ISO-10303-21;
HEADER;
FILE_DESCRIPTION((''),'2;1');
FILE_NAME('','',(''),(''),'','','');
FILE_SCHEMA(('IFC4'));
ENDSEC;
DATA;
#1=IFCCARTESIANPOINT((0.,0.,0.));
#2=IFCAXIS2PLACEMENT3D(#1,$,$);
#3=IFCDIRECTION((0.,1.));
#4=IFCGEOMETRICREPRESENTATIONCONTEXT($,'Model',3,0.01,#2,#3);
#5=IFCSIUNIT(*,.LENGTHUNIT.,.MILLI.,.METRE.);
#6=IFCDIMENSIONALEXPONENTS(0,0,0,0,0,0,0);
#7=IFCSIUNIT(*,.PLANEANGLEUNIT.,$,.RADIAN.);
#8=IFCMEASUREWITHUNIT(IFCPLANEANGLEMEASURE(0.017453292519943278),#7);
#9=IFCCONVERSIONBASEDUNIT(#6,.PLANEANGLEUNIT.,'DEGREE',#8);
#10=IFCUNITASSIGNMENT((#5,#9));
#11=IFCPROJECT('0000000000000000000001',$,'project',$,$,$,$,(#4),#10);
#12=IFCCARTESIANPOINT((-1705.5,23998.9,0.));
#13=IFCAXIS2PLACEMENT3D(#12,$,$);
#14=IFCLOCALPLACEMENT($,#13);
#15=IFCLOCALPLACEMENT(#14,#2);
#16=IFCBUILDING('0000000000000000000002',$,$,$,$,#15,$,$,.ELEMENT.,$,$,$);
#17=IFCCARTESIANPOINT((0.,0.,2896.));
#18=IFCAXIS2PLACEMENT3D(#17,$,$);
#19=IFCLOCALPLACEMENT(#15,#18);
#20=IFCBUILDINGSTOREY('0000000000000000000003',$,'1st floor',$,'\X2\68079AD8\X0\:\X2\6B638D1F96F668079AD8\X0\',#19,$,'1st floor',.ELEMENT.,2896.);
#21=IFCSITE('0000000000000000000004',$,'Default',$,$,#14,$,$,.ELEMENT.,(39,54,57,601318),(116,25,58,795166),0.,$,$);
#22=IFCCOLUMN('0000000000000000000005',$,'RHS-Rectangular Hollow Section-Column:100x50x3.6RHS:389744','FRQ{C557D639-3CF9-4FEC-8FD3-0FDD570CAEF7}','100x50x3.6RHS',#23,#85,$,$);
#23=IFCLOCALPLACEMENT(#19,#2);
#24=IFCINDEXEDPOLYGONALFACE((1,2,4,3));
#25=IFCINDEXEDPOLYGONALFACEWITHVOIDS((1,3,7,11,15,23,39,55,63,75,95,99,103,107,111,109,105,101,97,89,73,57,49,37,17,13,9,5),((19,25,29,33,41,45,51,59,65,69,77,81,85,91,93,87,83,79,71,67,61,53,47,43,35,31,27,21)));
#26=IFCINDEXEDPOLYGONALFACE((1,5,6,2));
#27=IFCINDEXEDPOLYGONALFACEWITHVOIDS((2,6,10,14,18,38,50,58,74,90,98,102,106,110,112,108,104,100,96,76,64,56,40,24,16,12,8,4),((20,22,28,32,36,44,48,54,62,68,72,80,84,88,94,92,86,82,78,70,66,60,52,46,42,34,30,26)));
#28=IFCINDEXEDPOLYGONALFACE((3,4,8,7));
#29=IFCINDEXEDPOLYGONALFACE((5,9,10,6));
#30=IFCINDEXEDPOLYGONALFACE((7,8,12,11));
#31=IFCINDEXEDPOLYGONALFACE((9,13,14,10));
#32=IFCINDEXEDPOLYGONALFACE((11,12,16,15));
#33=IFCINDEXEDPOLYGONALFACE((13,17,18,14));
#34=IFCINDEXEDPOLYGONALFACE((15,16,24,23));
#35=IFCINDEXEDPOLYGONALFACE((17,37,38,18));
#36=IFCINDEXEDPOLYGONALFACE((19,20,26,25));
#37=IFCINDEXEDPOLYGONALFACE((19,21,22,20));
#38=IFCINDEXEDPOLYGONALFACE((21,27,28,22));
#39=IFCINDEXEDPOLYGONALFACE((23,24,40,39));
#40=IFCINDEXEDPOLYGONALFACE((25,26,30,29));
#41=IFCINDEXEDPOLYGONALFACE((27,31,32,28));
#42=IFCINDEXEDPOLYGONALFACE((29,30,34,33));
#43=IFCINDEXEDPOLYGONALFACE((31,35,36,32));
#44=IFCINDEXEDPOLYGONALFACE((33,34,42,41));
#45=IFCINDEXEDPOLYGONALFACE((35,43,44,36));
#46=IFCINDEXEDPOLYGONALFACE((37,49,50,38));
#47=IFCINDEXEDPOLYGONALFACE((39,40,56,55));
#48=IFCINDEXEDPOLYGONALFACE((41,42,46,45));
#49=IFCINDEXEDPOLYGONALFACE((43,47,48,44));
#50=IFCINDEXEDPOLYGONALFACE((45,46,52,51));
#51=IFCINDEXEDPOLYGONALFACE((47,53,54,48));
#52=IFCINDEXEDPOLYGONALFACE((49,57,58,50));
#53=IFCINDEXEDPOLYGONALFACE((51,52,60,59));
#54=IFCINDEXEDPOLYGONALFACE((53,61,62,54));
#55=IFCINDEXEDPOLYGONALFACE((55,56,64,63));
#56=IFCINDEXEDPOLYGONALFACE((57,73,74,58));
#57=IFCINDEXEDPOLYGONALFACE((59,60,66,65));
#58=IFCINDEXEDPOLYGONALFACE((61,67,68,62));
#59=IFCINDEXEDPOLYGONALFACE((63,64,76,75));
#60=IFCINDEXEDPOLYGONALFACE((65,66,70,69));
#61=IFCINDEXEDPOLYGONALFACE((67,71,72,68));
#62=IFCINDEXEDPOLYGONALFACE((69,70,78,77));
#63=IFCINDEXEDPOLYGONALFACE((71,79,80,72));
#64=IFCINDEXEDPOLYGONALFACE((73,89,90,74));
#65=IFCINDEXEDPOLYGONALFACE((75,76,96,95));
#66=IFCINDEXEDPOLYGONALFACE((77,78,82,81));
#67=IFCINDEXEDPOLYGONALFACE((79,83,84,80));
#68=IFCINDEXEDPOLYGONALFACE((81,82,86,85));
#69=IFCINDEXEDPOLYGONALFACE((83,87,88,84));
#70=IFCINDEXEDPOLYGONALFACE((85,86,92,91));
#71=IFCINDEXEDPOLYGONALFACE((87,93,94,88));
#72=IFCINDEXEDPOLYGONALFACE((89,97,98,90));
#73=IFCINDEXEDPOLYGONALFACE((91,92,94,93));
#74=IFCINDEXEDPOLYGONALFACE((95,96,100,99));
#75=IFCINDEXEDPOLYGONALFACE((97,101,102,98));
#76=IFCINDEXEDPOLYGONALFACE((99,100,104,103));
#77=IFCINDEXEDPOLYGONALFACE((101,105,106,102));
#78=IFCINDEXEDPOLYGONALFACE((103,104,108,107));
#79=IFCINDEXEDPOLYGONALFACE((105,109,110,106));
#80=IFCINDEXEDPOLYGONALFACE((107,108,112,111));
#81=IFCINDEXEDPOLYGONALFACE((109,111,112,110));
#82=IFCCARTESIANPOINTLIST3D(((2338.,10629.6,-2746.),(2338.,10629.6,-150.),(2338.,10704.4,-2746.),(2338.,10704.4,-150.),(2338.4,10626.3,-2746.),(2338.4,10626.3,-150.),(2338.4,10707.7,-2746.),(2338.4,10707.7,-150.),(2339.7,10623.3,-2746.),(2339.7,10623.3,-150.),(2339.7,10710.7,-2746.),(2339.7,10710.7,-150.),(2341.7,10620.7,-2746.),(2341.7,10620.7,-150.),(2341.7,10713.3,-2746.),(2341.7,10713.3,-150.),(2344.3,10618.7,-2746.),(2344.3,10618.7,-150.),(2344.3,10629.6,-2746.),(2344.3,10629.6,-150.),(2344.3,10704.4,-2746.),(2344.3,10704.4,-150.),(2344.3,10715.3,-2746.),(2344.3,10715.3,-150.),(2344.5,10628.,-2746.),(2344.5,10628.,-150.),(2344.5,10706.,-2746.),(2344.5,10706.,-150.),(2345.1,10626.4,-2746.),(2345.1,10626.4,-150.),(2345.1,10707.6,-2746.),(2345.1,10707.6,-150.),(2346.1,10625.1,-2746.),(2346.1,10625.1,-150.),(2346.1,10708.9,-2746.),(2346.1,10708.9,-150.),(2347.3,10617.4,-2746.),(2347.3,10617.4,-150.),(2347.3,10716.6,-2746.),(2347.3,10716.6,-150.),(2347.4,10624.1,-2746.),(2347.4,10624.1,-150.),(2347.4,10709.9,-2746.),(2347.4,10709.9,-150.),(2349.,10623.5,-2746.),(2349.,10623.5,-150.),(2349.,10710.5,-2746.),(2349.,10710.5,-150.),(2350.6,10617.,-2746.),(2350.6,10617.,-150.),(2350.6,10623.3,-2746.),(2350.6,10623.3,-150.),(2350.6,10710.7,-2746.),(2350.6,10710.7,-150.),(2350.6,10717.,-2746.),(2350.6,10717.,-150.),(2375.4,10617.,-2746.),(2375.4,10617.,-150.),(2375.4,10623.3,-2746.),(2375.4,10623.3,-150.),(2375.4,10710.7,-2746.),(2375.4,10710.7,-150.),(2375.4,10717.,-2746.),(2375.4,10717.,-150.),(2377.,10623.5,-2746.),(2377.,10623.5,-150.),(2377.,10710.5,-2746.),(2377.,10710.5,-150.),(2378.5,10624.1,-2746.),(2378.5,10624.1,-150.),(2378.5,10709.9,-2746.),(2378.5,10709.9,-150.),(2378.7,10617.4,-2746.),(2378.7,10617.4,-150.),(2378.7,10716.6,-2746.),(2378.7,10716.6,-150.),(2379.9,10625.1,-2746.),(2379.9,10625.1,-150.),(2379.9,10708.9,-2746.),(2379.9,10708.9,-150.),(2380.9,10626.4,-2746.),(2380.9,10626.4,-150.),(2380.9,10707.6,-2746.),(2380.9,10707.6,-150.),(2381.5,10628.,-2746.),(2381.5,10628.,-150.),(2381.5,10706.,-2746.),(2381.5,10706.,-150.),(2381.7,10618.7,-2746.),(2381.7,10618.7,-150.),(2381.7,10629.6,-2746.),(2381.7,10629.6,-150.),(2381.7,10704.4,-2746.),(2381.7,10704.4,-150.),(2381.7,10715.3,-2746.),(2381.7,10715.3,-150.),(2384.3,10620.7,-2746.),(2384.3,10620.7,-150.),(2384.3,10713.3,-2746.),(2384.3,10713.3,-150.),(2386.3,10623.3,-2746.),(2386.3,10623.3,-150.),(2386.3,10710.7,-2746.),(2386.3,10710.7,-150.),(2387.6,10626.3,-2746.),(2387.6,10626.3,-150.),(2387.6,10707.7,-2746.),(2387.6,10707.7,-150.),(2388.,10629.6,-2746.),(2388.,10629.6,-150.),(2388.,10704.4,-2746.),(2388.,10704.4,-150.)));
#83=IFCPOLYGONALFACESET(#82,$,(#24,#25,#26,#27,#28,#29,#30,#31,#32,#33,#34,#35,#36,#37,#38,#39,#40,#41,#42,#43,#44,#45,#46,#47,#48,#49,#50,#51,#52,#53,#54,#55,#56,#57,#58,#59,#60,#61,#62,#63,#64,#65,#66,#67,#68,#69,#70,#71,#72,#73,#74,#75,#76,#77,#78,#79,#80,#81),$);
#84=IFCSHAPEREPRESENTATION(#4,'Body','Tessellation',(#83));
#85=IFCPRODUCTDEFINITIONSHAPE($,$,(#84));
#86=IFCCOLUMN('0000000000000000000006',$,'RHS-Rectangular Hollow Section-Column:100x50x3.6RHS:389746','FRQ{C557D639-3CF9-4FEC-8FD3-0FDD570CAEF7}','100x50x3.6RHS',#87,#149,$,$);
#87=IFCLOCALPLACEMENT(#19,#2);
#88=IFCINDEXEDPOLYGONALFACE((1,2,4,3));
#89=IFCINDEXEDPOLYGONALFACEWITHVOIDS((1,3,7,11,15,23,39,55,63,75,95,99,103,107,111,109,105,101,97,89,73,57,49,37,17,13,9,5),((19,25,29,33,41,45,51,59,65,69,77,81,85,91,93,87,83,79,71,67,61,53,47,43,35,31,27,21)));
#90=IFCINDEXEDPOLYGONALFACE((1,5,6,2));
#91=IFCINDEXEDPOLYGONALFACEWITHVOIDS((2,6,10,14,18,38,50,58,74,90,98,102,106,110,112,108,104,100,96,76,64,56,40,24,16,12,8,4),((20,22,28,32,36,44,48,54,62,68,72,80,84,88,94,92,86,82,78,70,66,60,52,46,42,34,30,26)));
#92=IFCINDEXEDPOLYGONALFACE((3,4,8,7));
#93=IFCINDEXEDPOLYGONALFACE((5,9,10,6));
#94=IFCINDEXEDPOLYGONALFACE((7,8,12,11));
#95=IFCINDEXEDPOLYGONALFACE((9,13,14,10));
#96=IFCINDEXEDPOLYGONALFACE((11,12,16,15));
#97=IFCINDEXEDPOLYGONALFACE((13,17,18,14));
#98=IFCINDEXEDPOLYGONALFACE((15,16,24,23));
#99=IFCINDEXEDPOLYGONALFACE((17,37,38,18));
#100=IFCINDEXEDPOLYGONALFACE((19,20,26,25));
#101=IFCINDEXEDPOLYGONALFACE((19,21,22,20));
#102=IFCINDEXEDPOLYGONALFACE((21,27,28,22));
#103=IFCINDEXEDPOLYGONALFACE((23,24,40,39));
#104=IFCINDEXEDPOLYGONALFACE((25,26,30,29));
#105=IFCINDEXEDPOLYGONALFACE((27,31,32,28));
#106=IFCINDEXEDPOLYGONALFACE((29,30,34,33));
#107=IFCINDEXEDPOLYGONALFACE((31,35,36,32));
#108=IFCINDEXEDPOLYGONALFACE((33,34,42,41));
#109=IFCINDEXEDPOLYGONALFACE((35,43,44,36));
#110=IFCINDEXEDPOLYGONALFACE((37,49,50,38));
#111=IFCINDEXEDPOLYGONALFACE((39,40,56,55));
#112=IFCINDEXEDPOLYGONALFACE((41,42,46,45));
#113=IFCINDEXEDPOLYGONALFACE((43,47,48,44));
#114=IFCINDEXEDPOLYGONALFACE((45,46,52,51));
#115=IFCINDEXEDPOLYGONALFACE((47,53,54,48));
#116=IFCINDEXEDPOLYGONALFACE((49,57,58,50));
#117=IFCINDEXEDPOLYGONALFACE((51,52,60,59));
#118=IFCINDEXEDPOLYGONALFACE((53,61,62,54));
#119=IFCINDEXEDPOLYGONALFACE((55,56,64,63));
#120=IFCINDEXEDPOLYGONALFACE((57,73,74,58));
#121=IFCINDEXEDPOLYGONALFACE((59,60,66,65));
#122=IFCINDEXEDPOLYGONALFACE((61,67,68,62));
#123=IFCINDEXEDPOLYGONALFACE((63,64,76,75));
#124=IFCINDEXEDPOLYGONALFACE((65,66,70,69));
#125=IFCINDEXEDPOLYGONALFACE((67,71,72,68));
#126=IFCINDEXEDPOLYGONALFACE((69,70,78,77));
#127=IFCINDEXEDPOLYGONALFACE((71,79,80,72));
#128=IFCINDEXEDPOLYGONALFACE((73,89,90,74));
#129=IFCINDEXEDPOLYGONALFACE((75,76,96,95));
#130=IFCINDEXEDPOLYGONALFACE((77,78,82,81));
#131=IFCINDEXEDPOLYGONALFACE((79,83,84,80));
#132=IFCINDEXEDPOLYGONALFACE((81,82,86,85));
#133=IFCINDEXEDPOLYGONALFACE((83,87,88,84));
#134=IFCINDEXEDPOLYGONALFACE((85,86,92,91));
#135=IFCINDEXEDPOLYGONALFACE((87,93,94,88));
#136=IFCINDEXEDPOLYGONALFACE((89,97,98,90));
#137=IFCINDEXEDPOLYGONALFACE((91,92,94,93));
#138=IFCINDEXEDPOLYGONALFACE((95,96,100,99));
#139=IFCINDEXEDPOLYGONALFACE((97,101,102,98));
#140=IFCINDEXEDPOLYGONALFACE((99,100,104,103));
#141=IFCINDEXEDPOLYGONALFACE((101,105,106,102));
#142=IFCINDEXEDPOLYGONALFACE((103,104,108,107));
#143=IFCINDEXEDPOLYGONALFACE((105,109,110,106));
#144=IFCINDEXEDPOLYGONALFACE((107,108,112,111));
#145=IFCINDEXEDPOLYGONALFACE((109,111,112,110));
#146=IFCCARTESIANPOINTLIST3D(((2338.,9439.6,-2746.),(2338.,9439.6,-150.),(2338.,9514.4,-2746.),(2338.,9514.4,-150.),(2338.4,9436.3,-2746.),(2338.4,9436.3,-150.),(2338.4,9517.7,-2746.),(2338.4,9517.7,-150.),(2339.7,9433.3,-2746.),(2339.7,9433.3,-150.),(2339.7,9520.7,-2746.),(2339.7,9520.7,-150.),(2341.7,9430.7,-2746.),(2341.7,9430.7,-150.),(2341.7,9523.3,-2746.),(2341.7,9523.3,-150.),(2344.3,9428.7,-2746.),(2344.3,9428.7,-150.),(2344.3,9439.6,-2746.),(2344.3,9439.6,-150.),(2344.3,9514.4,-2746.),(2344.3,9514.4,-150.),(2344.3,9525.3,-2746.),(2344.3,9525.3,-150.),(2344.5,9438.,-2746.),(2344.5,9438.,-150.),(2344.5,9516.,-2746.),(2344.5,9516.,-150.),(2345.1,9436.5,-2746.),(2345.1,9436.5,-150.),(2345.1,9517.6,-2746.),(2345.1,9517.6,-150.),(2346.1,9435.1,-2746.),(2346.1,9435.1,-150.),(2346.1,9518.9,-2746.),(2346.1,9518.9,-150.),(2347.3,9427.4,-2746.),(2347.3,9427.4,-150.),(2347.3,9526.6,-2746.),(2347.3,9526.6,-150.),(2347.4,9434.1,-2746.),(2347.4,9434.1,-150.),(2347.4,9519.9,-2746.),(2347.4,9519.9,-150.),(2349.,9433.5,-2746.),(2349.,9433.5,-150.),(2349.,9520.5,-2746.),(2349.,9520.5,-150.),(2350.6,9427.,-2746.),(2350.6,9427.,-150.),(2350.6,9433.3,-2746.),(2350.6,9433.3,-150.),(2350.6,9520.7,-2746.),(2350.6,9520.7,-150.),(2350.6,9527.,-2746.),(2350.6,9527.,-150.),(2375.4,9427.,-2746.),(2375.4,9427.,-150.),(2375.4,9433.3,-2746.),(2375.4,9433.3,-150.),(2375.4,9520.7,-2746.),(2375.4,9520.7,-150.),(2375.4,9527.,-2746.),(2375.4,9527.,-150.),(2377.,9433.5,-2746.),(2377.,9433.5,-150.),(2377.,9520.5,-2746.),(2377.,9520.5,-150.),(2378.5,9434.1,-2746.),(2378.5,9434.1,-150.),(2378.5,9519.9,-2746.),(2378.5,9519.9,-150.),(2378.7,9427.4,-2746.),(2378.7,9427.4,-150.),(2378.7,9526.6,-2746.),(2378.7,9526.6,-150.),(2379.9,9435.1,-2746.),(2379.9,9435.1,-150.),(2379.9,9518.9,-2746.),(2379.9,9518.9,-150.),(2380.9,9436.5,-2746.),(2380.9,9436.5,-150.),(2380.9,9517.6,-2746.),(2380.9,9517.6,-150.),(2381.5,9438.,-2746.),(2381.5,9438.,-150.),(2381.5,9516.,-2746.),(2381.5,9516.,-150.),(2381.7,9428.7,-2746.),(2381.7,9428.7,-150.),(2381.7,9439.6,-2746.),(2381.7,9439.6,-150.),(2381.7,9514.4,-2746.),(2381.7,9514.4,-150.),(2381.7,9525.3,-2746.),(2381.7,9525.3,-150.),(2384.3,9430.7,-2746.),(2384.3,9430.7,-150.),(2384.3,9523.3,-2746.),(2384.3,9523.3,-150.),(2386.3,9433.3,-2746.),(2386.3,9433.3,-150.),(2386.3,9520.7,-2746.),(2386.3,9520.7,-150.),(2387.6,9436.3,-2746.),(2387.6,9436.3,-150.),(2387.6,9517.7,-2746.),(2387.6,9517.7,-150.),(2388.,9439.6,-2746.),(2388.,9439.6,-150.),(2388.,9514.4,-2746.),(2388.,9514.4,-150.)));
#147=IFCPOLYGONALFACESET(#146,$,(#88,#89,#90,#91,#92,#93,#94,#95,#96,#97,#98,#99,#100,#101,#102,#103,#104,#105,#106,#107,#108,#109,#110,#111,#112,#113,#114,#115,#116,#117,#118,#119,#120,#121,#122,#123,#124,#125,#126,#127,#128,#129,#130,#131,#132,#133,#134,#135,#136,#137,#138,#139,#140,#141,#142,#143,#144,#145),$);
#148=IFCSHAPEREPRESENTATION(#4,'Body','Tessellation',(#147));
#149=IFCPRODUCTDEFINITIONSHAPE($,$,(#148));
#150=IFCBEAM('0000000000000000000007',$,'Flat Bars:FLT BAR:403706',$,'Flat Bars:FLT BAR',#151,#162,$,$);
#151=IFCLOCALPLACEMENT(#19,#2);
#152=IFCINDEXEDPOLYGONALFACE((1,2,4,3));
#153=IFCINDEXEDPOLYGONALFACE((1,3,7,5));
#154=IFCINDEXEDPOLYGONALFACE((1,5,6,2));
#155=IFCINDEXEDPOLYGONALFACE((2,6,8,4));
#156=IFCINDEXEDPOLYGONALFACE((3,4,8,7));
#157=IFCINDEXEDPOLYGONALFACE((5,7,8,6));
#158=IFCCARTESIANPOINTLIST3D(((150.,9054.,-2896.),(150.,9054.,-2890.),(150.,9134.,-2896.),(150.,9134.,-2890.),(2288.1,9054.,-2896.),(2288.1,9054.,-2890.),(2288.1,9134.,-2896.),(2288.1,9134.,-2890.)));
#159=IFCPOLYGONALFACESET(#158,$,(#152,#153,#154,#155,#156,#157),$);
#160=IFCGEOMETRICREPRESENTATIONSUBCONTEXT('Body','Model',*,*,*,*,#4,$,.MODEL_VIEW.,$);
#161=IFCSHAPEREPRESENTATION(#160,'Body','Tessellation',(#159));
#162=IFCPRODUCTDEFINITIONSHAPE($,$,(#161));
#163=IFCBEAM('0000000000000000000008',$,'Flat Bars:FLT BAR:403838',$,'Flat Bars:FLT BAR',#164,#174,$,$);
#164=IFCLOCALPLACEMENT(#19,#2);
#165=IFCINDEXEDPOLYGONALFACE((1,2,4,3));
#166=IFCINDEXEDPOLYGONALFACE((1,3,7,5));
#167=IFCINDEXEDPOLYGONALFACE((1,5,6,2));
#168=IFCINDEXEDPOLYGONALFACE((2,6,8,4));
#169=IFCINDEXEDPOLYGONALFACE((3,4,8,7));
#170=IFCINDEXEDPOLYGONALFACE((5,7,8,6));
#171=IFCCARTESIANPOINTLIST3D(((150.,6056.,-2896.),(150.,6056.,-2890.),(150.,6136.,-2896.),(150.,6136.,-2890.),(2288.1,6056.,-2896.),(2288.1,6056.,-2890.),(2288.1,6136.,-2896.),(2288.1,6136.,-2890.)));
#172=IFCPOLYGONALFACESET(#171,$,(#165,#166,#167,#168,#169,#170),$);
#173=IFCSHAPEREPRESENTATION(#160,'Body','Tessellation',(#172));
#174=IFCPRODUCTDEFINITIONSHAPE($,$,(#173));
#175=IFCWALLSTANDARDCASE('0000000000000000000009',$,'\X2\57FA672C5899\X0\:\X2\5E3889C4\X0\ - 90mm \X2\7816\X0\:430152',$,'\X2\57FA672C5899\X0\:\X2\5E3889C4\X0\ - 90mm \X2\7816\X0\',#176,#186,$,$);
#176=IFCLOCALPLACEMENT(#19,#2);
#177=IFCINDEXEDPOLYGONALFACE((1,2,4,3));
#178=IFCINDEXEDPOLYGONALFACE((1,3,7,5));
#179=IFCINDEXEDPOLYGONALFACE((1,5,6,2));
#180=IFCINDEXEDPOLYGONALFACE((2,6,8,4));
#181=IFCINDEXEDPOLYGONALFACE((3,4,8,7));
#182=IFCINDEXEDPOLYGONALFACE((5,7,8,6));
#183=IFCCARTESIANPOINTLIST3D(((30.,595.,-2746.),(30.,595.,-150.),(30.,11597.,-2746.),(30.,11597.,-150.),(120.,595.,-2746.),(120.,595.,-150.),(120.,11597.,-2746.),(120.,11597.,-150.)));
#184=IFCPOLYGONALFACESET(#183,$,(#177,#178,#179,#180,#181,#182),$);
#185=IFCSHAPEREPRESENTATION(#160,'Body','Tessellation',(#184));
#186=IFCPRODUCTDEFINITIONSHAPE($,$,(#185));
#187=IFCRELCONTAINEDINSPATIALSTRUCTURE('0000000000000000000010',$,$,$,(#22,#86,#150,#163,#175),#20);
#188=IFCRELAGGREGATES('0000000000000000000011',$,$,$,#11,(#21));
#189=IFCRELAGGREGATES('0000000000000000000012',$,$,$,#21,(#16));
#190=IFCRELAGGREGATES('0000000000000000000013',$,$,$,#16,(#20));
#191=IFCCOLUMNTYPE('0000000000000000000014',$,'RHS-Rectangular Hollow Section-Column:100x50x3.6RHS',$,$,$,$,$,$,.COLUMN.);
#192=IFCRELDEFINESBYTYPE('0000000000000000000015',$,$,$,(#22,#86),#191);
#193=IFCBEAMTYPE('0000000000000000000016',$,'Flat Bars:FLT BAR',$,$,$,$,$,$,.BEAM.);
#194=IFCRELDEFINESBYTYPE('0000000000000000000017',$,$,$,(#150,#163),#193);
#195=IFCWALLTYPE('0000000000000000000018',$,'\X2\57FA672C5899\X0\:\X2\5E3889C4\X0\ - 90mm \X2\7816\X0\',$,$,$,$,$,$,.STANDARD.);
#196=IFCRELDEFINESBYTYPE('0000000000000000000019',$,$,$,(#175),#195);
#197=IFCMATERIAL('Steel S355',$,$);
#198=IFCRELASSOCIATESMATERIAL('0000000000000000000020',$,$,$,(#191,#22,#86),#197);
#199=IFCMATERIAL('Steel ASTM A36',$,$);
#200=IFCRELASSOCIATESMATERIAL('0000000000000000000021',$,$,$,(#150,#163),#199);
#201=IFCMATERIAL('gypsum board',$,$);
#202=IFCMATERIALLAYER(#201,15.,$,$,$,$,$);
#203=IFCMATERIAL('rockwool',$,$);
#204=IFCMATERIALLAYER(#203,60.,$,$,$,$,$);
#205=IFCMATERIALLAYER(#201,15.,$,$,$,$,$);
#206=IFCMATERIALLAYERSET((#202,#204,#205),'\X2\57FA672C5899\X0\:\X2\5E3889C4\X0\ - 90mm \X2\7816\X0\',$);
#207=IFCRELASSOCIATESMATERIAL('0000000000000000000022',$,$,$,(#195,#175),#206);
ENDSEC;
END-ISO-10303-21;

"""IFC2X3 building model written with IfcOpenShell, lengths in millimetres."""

from ifc_helpers import new_model, entity, si_unit, converted_unit, direction, frame, frame_2d, origin, origin_2d, origin_2d_with_axis, place, context, subcontext, project, spatial, rectangle, hollow_rectangle, extrude, clip, halfspace, material, layer, layer_set, layer_usage, type_object, element, save


model = new_model("IFC2X3")

# Units and contexts
model_context = context("Model", 3, precision=0.01, world=origin(), true_north=direction((0.0, 1.0)))
body_context = subcontext(model_context, "Body", "Model", "MODEL_VIEW")
ifc_project = project(units=[si_unit("LENGTHUNIT", "METRE", prefix="MILLI"), converted_unit("PLANEANGLEUNIT", "DEGREE", entity("IfcPlaneAngleMeasure", 0.017453292519943278), si_unit("PLANEANGLEUNIT", "RADIAN"), dimensions=[0, 0, 0, 0, 0, 0, 0])], contexts=[model_context])

# Site, building, storey
site_placement = place(None, frame((-1705.5, 23998.9, 0.0)))
site = spatial("IfcSite", under=ifc_project, at=site_placement, Name="Default", CompositionType="ELEMENT", RefLatitude=(39, 54, 57, 601318), RefLongitude=(116, 25, 58, 795166), RefElevation=0.0)
building_placement = place(site_placement, origin())
building = spatial("IfcBuilding", under=site, at=building_placement, CompositionType="ELEMENT")
storey_placement = place(building_placement, frame((0.0, 0.0, 2896.0)))
storey = spatial("IfcBuildingStorey", under=building, at=storey_placement, Name="1st floor", ObjectType="标高:正负零标高", LongName="1st floor", CompositionType="ELEMENT", Elevation=2896.0)

# Columns
ifc_material_1 = material(Name="Steel S355")
column_type = type_object("IfcColumnType", Name="RHS-Rectangular Hollow Section-Column:100x50x3.6RHS", PredefinedType="COLUMN", material=ifc_material_1)
column_1_placement = place(storey_placement, frame((2363.0, 10667.0, -150.0), z_axis=(0.0, 0.0, 1.0), x_axis=(-1.0, 0.0, 0.0)))
element("IfcColumn", 1, at=column_1_placement, inside=storey, type_object=column_type, material=ifc_material_1, Name="RHS-Rectangular Hollow Section-Column:100x50x3.6RHS:389744", Description="FRQ{C557D639-3CF9-4FEC-8FD3-0FDD570CAEF7}", ObjectType="100x50x3.6RHS", context=model_context, shape_type="Clipping", body=[
    clip(extrude(hollow_rectangle(XDim=50.0, YDim=100.0, WallThickness=6.3, InnerFilletRadius=6.3, OuterFilletRadius=12.6, at=origin_2d()), origin(), (0.0, 0.0, -1.0), 2651.9), halfspace(frame((2363.0, 10667.0, -2596.0), z_axis=(0.0, 0.0, 1.0), x_axis=(-1.0, 0.0, 0.0)), True)),
])
column_2_placement = place(storey_placement, frame((2363.0, 9477.0, -150.0), z_axis=(0.0, 0.0, 1.0), x_axis=(-1.0, 0.0, 0.0)))
element("IfcColumn", 2, at=column_2_placement, inside=storey, type_object=column_type, material=ifc_material_1, Name="RHS-Rectangular Hollow Section-Column:100x50x3.6RHS:389746", Description="FRQ{C557D639-3CF9-4FEC-8FD3-0FDD570CAEF7}", ObjectType="100x50x3.6RHS", context=model_context, shape_type="Clipping", body=[
    clip(extrude(hollow_rectangle(XDim=50.0, YDim=100.0, WallThickness=6.3, InnerFilletRadius=6.3, OuterFilletRadius=12.6, at=origin_2d()), origin(), (0.0, 0.0, -1.0), 2651.9), halfspace(frame((2363.0, 9477.0, -2596.0), z_axis=(0.0, 0.0, 1.0), x_axis=(-1.0, 0.0, 0.0)), True)),
])

# Beams
ifc_material_2 = material(Name="Steel ASTM A36")
beam_type_1 = type_object("IfcBeamType", Name="Flat Bars:FLT BAR", PredefinedType="BEAM")
for number, where, name in (
    (3, (150.0, 9094.0, -2890.0), "Flat Bars:FLT BAR:403706"),
    (4, (150.0, 6096.0, -2890.0), "Flat Bars:FLT BAR:403838"),
):
    element("IfcBeam", number, at=place(storey_placement, frame(where)), inside=storey, type_object=beam_type_1, material=ifc_material_2, Name=name, ObjectType="Flat Bars:FLT BAR", context=body_context, shape_type="SweptSolid", body=[
        extrude(rectangle(XDim=6.0, YDim=80.0, at=origin_2d_with_axis()), frame((0.0, 0.0, -3.0), z_axis=(1.0, 0.0, 0.0), x_axis=(0.0, 0.0, -1.0)), (0.0, 0.0, 1.0), 2138.1),
    ])

# Wall
ifc_material_3 = material(Name="gypsum board")
ifc_layer_1 = layer(ifc_material_3, 15.0)
ifc_material_4 = material(Name="rockwool")
ifc_layer_2 = layer(ifc_material_4, 60.0)
ifc_layer_3 = layer(ifc_material_3, 15.0)
ifc_layer_set = layer_set([ifc_layer_1, ifc_layer_2, ifc_layer_3], Name="基本墙:常规 - 90mm 砖")
ifc_layer_usage = layer_usage(ifc_layer_set, "AXIS2", "NEGATIVE", 45.0)
wall_type = type_object("IfcWallType", Name="基本墙:常规 - 90mm 砖", PredefinedType="STANDARD", material=ifc_layer_set)
wall_placement = place(storey_placement, frame((75.0, 11597.0, -2746.0), z_axis=(0.0, 0.0, 1.0), x_axis=(0.0, -1.0, 0.0)))
element("IfcWallStandardCase", 5, at=wall_placement, inside=storey, type_object=wall_type, material=ifc_layer_usage, Name="基本墙:常规 - 90mm 砖:430152", ObjectType="基本墙:常规 - 90mm 砖", context=body_context, shape_type="SweptSolid", body=[
    extrude(rectangle(XDim=11002.0, YDim=90.0, at=frame_2d((5501.0, 0.0), x_axis=(-1.0, 0.0))), origin(), (0.0, 0.0, 1.0), 2596.0),
])

save(model, "model.ifc")
